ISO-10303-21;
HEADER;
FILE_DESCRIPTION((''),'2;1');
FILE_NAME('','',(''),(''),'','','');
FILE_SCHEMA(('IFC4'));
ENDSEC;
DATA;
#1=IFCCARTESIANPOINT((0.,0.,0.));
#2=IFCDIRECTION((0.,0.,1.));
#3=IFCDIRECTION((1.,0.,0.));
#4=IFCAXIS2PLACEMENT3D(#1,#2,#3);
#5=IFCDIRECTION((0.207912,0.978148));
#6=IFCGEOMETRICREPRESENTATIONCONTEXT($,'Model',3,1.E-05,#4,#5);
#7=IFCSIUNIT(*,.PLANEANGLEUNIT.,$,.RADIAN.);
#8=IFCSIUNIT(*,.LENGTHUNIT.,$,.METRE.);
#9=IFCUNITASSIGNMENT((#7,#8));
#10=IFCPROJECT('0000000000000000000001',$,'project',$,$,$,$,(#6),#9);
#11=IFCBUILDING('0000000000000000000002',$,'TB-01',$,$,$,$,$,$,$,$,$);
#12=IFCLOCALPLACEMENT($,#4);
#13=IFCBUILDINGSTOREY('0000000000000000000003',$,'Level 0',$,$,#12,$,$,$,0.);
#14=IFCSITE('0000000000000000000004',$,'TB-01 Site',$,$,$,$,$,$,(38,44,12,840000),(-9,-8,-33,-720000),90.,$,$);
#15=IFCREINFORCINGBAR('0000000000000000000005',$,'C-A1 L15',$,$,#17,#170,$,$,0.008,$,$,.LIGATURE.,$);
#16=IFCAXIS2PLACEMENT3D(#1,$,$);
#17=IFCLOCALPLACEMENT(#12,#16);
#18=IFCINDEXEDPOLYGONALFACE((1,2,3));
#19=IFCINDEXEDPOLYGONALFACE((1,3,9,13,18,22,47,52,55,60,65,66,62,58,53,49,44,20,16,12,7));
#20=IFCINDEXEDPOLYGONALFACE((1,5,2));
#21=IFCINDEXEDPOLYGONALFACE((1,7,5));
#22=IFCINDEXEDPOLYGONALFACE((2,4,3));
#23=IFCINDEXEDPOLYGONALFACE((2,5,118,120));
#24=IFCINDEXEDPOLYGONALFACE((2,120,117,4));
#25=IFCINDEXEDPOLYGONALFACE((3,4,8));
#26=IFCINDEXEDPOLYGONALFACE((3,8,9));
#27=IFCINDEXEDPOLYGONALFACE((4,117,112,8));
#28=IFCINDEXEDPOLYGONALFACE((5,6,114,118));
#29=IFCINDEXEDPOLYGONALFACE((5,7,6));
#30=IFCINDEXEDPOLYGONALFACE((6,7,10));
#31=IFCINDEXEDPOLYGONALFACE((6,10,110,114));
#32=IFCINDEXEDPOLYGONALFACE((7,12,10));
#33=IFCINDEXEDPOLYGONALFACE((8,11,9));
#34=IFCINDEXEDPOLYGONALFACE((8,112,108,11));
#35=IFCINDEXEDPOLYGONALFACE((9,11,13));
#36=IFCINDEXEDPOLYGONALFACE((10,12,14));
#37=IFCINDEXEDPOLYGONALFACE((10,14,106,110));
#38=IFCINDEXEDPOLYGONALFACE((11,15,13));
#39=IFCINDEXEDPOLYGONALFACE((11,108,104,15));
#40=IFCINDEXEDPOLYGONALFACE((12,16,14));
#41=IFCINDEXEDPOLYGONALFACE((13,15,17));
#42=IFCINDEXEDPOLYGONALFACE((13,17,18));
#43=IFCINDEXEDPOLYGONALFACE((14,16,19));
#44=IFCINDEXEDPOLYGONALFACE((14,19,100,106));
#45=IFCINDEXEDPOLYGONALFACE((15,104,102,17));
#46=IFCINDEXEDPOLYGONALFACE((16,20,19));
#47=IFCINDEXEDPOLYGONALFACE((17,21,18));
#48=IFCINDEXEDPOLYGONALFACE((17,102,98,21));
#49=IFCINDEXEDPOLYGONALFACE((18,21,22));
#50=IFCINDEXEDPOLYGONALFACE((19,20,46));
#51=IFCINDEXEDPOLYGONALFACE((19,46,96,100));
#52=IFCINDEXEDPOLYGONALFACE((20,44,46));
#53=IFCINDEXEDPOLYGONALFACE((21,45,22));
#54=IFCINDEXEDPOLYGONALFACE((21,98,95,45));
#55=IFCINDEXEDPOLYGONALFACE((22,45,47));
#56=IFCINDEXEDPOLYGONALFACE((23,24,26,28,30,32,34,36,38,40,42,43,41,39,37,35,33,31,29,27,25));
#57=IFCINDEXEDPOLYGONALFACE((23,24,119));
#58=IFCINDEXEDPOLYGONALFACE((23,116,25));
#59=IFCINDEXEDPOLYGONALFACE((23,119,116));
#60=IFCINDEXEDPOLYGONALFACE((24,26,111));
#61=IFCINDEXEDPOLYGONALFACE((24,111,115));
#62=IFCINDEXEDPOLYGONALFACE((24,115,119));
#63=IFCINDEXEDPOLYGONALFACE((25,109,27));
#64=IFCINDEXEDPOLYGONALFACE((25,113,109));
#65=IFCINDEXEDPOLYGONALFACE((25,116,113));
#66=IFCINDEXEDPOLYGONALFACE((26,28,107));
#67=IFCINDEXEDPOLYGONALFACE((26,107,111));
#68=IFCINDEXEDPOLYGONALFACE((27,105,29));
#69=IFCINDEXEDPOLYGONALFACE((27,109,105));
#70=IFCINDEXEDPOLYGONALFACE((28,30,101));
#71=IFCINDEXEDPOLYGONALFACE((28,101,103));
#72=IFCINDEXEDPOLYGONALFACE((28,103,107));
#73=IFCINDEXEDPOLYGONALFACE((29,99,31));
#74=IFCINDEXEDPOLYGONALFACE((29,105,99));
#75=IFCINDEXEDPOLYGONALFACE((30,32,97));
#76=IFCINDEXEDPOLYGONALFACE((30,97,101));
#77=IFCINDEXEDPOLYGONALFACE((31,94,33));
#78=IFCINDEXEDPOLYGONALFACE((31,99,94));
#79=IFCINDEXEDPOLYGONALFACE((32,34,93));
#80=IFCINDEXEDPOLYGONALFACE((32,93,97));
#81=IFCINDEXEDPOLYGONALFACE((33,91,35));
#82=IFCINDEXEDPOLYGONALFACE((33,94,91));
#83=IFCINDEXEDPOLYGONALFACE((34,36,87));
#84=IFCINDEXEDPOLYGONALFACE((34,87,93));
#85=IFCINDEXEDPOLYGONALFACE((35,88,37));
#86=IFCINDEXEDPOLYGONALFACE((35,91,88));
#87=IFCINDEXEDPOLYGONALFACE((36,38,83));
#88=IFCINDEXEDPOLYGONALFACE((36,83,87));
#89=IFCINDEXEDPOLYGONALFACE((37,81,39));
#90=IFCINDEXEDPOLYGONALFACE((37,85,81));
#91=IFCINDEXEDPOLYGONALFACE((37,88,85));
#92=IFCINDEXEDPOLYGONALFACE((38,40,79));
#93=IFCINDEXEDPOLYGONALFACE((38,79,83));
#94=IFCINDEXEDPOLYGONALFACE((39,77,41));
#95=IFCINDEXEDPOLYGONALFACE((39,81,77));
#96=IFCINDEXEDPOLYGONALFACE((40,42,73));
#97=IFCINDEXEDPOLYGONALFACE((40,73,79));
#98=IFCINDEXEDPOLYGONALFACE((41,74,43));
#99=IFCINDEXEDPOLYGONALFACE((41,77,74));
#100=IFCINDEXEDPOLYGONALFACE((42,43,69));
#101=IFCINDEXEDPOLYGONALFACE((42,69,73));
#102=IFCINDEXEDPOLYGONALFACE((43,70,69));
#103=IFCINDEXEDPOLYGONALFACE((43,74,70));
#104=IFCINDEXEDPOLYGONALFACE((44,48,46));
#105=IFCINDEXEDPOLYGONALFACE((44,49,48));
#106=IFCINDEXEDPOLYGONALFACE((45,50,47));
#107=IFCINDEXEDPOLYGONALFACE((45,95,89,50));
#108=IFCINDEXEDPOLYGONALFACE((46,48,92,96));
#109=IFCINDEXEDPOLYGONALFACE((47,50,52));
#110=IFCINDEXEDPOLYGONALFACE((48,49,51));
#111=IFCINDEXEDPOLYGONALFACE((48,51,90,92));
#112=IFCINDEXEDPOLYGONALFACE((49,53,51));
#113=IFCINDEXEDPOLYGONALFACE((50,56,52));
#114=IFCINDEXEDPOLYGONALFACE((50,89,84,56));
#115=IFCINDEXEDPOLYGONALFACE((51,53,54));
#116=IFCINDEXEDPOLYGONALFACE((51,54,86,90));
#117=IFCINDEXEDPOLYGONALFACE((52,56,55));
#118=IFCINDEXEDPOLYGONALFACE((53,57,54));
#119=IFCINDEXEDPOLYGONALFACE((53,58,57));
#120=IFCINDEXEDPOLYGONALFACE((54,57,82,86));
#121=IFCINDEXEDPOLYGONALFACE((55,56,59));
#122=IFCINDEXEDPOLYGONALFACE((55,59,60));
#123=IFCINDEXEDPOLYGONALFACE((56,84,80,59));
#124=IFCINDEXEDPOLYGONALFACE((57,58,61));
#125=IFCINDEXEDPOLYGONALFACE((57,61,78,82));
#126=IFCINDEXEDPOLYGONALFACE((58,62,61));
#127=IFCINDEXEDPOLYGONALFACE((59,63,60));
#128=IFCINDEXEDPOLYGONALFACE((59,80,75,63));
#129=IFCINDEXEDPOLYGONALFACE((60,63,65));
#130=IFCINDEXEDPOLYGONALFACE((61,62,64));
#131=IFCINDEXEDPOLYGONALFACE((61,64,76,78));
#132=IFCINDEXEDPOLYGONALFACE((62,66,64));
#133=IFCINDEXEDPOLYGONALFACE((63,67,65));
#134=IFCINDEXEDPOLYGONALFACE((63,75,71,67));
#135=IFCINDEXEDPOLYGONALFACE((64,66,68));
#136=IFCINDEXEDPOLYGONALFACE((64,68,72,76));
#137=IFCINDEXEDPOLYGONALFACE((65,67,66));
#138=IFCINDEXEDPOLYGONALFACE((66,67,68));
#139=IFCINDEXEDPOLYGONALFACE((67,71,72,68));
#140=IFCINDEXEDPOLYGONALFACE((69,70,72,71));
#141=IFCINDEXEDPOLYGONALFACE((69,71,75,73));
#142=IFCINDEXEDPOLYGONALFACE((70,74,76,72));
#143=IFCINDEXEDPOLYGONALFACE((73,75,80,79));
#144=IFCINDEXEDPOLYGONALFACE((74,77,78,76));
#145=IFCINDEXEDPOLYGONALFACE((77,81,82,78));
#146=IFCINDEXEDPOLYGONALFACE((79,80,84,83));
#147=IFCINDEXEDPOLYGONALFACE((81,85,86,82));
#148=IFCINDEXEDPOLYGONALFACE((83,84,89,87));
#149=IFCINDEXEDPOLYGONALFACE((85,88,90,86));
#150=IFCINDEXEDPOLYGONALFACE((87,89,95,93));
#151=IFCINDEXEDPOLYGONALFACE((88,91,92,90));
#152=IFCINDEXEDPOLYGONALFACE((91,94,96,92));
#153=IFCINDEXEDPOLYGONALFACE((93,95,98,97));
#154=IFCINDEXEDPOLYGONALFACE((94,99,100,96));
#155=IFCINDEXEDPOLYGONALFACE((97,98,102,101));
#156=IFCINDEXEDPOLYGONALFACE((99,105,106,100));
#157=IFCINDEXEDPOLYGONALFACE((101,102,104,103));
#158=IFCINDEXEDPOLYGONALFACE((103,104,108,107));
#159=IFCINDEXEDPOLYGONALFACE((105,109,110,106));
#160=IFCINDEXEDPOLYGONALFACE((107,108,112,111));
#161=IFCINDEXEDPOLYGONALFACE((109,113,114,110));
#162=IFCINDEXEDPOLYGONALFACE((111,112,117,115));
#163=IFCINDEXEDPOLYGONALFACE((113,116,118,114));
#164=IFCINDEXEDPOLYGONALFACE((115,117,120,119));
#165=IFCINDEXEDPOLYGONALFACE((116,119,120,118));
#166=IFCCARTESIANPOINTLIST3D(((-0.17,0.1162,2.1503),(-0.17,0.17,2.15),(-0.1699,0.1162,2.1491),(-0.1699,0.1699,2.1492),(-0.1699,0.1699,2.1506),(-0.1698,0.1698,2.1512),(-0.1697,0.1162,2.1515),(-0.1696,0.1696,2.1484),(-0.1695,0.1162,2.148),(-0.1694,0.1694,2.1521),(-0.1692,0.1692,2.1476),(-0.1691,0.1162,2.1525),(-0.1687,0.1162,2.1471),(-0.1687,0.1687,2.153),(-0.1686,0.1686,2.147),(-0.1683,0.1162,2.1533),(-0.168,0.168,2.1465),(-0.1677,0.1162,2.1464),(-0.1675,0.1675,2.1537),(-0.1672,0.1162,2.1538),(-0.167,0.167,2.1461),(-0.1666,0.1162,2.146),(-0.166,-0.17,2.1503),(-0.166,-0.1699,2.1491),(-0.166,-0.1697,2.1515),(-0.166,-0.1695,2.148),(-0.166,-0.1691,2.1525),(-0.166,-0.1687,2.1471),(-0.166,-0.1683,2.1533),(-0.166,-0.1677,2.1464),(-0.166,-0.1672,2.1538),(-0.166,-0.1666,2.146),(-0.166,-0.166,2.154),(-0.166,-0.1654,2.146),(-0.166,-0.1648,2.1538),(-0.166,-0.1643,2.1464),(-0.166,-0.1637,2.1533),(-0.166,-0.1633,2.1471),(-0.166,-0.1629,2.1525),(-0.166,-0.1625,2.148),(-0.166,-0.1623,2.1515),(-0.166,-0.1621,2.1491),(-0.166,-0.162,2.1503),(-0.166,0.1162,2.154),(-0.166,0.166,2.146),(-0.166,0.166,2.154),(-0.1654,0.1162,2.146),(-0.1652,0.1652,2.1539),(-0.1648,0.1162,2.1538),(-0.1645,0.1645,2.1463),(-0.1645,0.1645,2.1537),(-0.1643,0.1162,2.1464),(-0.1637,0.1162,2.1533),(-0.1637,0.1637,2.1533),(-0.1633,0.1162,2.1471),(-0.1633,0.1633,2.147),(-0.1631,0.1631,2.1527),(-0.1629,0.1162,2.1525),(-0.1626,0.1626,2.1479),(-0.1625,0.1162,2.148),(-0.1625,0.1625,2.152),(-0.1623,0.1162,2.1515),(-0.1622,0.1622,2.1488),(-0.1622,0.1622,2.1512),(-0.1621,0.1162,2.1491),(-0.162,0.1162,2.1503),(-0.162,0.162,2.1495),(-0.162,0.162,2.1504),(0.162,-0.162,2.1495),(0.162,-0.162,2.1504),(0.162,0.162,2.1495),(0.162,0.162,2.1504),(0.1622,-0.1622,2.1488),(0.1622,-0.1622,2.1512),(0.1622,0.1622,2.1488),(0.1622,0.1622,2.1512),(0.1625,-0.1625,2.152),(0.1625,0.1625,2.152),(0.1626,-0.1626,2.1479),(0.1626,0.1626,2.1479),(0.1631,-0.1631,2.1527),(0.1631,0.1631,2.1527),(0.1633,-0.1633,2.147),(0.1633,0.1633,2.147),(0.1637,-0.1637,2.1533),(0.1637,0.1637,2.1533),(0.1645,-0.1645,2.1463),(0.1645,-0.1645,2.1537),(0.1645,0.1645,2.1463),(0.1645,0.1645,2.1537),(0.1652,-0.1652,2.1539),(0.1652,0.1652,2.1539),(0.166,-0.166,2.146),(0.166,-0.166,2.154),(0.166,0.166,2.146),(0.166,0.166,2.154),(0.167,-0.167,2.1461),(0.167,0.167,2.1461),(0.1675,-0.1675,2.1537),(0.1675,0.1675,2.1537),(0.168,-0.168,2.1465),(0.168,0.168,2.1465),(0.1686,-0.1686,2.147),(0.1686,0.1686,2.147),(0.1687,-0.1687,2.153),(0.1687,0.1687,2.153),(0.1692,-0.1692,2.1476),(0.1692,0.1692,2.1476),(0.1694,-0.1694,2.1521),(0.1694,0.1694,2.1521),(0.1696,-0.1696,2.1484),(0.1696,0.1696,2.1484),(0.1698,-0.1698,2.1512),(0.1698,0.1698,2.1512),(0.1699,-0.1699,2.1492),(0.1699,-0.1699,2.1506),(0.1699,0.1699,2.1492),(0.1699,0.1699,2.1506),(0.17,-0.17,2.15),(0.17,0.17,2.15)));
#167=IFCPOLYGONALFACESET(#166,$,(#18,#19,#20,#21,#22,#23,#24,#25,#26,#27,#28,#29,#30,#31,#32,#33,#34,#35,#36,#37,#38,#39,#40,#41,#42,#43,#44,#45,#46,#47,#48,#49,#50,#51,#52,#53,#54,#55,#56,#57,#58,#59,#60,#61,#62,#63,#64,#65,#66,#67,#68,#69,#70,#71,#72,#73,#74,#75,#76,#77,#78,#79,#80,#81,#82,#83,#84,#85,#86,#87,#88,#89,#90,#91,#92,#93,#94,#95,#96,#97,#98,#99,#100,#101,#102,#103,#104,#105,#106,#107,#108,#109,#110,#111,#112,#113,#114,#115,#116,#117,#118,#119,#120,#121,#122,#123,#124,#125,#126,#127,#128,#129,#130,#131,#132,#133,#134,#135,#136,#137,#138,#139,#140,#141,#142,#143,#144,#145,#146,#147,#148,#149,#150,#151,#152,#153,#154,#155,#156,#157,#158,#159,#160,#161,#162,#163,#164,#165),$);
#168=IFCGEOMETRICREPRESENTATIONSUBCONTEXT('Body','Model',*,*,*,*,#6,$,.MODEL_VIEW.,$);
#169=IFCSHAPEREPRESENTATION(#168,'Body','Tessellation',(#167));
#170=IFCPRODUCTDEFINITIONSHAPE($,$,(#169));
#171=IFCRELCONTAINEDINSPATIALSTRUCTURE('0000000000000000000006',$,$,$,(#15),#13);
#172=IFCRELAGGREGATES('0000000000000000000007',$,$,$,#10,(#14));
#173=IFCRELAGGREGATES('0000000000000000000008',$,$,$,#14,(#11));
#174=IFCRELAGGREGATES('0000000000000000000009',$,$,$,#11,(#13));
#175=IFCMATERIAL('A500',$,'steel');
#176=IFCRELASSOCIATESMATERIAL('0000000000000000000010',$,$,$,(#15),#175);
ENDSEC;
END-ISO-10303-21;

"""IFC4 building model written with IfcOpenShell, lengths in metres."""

from ifc_helpers import new_model, entity, si_unit, direction, origin_with_axes, place, context, subcontext, project, spatial, material, element, save


model = new_model("IFC4")

# Units and contexts
model_context = context("Model", 3, precision=1e-05, world=origin_with_axes(), true_north=direction((0.207912, 0.978148)))
body_context = subcontext(model_context, "Body", "Model", "MODEL_VIEW")
ifc_project = project(units=[si_unit("PLANEANGLEUNIT", "RADIAN"), si_unit("LENGTHUNIT", "METRE")], contexts=[model_context])

# Site, building, storey
site = spatial("IfcSite", under=ifc_project, Name="TB-01 Site", RefLatitude=(38, 44, 12, 840000), RefLongitude=(-9, -8, -33, -720000), RefElevation=90.0)
building = spatial("IfcBuilding", under=site, Name="TB-01")
storey_placement = place(None, origin_with_axes())
storey = spatial("IfcBuildingStorey", under=building, at=storey_placement, Name="Level 0", Elevation=0.0)

# Reinforcing bar
ifc_material_1 = material(Name="A500", Category="steel")
reinforcing_bar_1_placement = place(storey_placement, origin_with_axes())
element("IfcReinforcingBar", 1, at=reinforcing_bar_1_placement, inside=storey, material=ifc_material_1, Name="C-A1 L15", NominalDiameter=0.008, PredefinedType="LIGATURE", context=body_context, shape_type="AdvancedSweptSolid", body=[
    entity("IfcSweptDiskSolid", entity("IfcPolyline", [entity("IfcCartesianPoint", [-0.166, -0.166, 2.15]), entity("IfcCartesianPoint", [0.166, -0.166, 2.15]), entity("IfcCartesianPoint", [0.166, 0.166, 2.15]), entity("IfcCartesianPoint", [-0.166, 0.166, 2.15]), entity("IfcCartesianPoint", [-0.166, 0.1162, 2.15])]), 0.004),
])

save(model, "model.ifc")
